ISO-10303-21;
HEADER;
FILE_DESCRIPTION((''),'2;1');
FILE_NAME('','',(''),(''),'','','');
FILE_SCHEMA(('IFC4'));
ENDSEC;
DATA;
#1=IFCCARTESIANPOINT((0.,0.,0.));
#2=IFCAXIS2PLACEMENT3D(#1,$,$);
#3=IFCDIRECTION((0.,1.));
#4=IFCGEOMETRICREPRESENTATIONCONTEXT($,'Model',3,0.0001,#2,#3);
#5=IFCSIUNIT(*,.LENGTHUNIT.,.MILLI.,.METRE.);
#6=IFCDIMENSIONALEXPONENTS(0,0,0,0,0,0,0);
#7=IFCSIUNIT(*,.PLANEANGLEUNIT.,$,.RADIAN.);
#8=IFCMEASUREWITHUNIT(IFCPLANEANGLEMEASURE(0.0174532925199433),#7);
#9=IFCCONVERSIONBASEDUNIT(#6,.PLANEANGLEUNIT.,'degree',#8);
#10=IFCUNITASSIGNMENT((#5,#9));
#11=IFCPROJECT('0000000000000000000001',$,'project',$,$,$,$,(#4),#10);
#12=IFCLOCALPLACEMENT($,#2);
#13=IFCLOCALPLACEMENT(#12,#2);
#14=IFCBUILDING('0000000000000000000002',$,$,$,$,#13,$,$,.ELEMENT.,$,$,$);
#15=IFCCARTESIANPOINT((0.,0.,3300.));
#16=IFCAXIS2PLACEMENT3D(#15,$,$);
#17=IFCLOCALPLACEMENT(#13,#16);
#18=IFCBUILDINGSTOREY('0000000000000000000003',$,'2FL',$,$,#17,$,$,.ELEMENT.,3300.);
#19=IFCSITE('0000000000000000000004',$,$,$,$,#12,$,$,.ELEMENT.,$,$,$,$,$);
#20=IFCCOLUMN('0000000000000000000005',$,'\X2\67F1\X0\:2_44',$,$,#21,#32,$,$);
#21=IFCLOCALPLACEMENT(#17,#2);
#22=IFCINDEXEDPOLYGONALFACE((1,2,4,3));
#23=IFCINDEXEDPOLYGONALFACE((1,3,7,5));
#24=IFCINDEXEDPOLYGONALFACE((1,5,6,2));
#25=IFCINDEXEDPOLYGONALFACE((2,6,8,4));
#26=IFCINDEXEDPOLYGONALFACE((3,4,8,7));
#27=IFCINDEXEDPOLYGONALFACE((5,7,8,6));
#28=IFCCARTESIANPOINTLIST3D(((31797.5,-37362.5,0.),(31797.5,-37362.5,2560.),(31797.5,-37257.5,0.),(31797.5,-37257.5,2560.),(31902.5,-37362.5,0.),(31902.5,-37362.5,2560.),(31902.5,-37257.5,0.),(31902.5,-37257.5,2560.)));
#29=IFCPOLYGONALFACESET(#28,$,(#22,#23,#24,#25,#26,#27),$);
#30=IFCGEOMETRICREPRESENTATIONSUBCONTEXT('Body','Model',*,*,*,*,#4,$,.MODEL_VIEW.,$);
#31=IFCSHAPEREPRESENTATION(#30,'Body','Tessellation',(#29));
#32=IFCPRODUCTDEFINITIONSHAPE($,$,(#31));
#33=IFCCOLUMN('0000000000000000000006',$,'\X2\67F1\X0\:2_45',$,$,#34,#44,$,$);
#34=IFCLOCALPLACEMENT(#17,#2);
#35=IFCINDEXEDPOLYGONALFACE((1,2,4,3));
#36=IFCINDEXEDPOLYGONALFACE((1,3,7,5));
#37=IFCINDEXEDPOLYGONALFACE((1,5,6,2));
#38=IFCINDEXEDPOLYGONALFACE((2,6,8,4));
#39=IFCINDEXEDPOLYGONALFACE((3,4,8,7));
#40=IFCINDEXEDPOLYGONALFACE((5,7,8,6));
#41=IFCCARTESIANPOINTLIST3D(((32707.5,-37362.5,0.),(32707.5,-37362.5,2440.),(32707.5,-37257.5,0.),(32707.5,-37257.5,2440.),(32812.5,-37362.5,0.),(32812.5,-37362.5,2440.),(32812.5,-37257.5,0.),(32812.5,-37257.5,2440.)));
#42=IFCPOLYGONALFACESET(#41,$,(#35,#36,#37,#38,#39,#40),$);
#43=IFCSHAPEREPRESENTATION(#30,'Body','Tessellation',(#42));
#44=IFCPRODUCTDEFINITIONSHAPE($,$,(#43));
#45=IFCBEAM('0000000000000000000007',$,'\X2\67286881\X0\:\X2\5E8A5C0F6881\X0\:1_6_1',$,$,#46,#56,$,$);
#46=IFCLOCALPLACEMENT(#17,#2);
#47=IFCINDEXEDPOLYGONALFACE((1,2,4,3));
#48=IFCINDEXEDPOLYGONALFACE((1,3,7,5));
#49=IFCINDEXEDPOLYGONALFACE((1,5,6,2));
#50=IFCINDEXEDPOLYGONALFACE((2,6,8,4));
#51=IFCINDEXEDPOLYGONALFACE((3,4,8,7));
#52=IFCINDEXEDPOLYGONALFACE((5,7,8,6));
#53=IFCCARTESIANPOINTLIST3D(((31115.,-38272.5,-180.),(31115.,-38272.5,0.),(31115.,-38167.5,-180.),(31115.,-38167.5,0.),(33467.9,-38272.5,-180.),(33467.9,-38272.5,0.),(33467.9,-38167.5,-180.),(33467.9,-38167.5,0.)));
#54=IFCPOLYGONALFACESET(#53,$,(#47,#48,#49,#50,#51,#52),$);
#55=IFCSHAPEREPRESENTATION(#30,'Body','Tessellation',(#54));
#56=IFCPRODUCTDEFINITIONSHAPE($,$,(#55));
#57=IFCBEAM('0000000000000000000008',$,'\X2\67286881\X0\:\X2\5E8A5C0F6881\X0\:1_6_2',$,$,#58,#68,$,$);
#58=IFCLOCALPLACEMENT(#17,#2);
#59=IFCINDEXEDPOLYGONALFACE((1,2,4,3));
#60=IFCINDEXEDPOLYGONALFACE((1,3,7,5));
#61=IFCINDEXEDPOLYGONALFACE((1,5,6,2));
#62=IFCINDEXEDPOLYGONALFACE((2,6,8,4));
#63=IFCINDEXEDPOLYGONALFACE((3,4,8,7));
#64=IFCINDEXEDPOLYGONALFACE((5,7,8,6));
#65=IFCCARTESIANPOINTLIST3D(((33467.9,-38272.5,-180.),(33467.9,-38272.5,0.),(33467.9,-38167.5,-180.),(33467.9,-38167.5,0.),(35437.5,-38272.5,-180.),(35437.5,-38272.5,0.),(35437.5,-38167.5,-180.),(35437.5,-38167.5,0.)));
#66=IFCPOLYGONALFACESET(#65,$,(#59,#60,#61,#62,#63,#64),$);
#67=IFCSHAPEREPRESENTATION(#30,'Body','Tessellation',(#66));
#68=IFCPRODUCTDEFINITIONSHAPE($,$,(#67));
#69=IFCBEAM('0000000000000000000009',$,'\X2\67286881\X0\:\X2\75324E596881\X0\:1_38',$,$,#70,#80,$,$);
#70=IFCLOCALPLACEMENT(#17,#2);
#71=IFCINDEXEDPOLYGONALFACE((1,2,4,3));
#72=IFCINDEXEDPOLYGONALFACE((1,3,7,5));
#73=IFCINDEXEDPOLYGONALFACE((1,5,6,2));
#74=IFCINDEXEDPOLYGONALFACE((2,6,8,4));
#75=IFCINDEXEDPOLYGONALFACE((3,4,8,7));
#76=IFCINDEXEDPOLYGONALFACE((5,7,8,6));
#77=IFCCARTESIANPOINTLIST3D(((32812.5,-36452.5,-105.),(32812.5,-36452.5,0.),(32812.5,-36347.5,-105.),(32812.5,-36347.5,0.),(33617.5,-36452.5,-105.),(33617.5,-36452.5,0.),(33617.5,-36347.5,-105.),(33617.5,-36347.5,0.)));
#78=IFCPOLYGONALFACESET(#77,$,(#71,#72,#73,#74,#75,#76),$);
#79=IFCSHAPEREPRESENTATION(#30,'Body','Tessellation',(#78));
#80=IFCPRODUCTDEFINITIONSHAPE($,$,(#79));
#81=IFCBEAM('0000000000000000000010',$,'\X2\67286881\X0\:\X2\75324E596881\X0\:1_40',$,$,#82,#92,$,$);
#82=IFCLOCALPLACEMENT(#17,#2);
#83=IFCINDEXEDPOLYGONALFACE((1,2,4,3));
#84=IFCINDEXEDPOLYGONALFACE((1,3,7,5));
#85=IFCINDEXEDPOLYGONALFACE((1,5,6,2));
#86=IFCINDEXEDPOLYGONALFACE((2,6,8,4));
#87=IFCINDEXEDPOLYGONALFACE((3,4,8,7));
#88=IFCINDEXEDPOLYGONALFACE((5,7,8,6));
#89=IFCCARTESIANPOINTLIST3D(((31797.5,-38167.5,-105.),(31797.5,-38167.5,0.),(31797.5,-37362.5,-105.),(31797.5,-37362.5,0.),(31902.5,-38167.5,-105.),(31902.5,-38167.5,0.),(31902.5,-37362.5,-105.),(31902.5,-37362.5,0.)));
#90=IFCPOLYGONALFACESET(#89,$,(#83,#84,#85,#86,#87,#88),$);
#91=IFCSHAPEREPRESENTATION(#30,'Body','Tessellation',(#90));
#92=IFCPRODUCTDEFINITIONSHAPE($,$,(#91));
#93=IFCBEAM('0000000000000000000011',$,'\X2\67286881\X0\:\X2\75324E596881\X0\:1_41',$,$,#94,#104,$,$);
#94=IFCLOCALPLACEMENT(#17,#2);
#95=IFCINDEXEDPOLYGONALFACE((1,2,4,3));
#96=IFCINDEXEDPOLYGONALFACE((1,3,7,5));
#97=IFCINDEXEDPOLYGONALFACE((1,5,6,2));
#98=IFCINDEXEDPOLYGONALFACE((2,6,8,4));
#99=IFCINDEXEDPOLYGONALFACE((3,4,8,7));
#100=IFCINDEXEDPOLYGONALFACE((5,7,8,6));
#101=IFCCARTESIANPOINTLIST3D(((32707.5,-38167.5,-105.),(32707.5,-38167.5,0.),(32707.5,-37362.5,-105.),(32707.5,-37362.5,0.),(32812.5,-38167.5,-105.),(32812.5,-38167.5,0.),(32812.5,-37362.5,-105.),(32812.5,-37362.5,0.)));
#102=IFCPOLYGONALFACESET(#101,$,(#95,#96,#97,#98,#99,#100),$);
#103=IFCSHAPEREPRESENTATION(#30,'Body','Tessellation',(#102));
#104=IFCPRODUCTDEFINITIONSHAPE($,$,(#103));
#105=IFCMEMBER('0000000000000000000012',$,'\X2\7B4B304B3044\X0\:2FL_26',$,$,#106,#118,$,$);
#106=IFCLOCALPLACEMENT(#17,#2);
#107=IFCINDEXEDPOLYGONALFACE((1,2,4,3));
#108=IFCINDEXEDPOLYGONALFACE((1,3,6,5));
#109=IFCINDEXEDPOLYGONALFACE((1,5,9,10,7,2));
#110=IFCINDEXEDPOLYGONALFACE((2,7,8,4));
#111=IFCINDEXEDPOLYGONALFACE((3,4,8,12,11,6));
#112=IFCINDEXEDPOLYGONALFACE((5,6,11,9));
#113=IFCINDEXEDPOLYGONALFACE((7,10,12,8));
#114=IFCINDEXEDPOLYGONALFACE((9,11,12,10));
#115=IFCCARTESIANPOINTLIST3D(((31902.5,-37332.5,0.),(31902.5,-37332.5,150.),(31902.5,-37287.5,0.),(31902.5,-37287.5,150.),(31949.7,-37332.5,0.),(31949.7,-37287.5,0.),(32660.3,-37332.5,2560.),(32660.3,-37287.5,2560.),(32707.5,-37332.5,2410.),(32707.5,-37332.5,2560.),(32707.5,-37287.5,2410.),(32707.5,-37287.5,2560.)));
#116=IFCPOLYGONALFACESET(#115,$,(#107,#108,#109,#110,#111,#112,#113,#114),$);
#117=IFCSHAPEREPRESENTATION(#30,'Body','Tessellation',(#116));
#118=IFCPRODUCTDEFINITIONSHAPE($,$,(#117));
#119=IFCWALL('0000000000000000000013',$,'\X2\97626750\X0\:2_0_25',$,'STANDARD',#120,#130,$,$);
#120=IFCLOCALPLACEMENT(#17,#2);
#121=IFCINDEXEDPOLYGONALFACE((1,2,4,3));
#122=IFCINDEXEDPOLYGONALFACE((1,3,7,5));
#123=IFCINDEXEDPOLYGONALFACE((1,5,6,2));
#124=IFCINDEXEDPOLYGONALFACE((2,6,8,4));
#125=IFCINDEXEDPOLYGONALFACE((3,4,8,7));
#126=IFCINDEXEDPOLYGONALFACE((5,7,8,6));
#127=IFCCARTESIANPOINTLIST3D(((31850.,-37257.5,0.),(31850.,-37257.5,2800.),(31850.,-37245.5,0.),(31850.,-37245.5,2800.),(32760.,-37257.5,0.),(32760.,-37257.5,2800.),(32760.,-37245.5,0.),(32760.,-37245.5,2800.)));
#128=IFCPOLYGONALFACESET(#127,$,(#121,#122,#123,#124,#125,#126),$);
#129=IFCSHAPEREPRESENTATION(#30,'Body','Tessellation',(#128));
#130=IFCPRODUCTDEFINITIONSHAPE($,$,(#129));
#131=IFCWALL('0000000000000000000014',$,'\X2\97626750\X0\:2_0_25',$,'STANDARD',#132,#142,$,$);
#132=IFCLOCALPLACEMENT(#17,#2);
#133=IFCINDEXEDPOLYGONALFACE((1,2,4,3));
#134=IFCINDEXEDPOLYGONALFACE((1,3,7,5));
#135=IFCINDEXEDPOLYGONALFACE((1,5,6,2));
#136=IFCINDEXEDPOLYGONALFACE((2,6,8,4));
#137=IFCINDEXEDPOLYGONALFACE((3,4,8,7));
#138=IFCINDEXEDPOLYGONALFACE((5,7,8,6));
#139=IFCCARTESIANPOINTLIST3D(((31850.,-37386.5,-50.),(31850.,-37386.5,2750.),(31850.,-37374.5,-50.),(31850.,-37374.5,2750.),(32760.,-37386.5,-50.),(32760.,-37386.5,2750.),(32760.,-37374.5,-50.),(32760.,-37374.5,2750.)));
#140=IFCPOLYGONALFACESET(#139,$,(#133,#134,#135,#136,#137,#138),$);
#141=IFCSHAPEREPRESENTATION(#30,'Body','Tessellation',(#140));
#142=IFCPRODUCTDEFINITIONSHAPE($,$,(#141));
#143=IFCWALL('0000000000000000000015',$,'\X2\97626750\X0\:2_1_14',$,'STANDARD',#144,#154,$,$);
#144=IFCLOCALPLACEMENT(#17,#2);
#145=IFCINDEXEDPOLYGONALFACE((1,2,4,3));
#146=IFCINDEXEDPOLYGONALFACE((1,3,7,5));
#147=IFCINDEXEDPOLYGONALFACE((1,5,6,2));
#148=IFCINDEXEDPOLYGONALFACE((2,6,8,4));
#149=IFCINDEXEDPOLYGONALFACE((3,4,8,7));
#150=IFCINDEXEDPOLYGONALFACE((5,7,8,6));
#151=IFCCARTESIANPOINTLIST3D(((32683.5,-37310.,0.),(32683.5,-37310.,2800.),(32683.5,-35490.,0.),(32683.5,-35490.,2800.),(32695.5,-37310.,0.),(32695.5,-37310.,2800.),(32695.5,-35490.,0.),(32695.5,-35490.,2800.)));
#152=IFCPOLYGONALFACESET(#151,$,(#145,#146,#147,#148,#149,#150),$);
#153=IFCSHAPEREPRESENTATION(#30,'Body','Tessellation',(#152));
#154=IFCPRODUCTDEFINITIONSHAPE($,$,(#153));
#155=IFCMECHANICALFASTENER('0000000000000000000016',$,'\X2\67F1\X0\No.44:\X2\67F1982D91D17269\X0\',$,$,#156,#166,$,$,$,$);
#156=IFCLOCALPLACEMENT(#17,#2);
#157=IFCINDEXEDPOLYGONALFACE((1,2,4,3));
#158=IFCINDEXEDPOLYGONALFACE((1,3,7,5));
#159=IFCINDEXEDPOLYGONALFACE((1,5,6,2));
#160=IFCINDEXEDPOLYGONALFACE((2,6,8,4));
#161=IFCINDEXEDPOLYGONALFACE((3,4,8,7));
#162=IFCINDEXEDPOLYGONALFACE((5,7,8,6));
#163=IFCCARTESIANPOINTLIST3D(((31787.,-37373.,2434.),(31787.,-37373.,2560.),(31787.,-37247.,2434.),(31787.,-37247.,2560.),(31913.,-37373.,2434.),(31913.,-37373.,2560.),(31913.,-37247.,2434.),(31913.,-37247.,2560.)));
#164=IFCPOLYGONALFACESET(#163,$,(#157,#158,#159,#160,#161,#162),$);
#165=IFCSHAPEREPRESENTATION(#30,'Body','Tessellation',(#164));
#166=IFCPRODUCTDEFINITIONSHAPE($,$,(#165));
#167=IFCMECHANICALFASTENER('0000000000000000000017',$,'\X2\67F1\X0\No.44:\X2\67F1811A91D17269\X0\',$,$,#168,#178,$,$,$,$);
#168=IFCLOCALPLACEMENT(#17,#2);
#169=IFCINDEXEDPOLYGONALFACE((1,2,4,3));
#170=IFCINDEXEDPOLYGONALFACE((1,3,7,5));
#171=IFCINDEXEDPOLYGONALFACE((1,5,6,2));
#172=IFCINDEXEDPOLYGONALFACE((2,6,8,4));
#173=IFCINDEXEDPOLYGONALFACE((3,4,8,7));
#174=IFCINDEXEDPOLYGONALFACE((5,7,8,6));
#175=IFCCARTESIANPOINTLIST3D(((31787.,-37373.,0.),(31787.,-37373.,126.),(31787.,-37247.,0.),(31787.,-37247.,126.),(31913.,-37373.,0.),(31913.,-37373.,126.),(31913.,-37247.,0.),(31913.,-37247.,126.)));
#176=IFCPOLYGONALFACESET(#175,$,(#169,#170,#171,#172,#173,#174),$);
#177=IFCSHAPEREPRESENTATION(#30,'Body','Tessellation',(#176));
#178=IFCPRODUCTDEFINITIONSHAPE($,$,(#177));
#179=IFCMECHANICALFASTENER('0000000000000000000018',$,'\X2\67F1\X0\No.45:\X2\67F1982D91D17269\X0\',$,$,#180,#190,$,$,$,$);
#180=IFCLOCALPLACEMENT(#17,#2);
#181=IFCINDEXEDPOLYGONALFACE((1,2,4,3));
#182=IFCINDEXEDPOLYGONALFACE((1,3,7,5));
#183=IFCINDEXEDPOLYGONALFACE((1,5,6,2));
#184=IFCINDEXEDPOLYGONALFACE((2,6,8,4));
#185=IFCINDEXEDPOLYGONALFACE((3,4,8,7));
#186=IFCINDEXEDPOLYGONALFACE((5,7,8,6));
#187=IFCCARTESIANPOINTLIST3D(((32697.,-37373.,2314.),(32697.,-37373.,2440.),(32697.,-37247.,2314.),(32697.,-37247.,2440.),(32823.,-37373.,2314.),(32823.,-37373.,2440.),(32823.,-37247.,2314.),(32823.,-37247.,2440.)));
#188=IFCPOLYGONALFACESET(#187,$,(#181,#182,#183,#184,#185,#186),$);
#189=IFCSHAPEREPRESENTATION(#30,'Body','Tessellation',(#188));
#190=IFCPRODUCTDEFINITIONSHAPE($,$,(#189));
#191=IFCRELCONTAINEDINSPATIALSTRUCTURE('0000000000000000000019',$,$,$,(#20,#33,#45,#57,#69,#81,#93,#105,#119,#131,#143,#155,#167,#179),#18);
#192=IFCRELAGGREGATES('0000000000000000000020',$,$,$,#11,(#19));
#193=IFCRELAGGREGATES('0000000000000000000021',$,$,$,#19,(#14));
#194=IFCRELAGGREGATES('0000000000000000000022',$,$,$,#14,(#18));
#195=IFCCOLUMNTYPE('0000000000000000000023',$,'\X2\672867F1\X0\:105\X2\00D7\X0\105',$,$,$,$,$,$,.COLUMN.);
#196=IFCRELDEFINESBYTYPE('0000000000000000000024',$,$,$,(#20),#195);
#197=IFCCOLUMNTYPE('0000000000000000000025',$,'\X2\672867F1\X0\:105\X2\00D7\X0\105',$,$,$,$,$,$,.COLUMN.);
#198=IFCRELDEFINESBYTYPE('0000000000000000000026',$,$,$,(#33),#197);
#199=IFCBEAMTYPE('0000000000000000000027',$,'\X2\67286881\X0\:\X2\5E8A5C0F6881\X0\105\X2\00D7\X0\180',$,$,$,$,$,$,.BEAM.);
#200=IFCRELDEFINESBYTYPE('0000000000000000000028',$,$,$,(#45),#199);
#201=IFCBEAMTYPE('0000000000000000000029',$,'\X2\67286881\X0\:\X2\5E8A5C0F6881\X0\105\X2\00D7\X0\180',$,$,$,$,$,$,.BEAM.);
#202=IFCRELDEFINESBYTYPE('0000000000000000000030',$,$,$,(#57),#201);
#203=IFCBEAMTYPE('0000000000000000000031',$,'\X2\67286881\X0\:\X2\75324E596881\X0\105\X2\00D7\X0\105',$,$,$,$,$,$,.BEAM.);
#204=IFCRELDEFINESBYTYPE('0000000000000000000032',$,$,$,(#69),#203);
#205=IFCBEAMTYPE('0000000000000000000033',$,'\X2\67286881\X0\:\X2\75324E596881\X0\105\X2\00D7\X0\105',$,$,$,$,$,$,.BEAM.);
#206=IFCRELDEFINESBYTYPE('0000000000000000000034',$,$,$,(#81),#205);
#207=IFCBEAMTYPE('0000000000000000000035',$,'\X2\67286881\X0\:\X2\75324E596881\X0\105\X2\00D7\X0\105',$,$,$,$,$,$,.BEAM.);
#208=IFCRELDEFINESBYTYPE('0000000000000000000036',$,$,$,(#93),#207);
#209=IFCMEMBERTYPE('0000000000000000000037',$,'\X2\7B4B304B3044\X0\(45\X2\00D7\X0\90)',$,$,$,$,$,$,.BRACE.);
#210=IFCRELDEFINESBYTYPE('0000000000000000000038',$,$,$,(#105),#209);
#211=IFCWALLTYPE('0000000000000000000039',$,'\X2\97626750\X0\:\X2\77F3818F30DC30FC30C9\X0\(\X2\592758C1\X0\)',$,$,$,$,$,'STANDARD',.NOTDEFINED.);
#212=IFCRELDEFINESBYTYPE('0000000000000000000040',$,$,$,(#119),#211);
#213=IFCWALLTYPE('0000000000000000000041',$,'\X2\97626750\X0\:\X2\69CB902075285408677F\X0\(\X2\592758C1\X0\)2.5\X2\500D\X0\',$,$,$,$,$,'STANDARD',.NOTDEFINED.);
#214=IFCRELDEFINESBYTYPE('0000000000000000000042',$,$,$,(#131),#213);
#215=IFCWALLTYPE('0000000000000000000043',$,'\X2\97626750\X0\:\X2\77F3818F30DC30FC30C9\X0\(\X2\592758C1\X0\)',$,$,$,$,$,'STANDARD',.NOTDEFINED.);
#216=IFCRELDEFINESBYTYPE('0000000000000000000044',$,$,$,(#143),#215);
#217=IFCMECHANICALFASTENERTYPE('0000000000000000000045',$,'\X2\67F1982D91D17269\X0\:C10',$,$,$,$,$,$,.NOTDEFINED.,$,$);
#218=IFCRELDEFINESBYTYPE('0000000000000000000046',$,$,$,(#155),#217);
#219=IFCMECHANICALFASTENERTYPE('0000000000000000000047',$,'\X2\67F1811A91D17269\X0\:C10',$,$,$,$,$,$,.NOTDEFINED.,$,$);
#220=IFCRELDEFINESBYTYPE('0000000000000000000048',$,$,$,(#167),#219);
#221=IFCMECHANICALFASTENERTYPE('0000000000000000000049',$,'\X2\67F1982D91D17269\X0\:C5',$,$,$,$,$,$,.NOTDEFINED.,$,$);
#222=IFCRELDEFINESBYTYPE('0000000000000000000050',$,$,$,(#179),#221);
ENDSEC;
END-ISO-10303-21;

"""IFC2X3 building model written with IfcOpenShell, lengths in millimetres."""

from ifc_helpers import new_model, entity, si_unit, converted_unit, direction, frame, origin, origin_with_axes, origin_2d, place, context, subcontext, project, spatial, polyline, rectangle, outline, extrude, type_object, element, save


model = new_model("IFC2X3")

# Units and contexts
model_context = context("Model", 3, precision=0.0001, world=origin(), true_north=direction((0.0, 1.0)))
body_context = subcontext(model_context, "Body", "Model", "MODEL_VIEW")
ifc_project = project(units=[si_unit("LENGTHUNIT", "METRE", prefix="MILLI"), converted_unit("PLANEANGLEUNIT", "degree", entity("IfcPlaneAngleMeasure", 0.0174532925199433), si_unit("PLANEANGLEUNIT", "RADIAN"), dimensions=[0, 0, 0, 0, 0, 0, 0])], contexts=[model_context])

# Site, building, storey
site_placement = place(None, origin())
site = spatial("IfcSite", under=ifc_project, at=site_placement, CompositionType="ELEMENT")
building_placement = place(site_placement, origin())
building = spatial("IfcBuilding", under=site, at=building_placement, CompositionType="ELEMENT")
storey_placement = place(building_placement, frame((0.0, 0.0, 3300.0)))
storey = spatial("IfcBuildingStorey", under=building, at=storey_placement, Name="2FL", CompositionType="ELEMENT", Elevation=3300.0)

# Columns
column_type_1 = type_object("IfcColumnType", Name="木柱:105×105", PredefinedType="COLUMN")
column_1_placement = place(storey_placement, frame((31850.0, -37310.0, 0.0)))
element("IfcColumn", 1, at=column_1_placement, inside=storey, type_object=column_type_1, Name="柱:2_44", context=body_context, shape_type="SweptSolid", body=[
    extrude(rectangle(XDim=105.0, YDim=105.0, at=origin_2d()), origin_with_axes(), (0.0, 0.0, 1.0), 2560.0),
])
column_type_2 = type_object("IfcColumnType", Name="木柱:105×105", PredefinedType="COLUMN")
column_2_placement = place(storey_placement, frame((32760.0, -37310.0, 0.0)))
element("IfcColumn", 2, at=column_2_placement, inside=storey, type_object=column_type_2, Name="柱:2_45", context=body_context, shape_type="SweptSolid", body=[
    extrude(rectangle(XDim=105.0, YDim=105.0, at=origin_2d()), origin_with_axes(), (0.0, 0.0, 1.0), 2440.0),
])

# Beams
beam_type_1 = type_object("IfcBeamType", Name="木梁:床小梁105×180", PredefinedType="BEAM")
beam_1_placement = place(storey_placement, frame((31115.0, -38220.0, -90.0), z_axis=(1.0, 0.0, 0.0), x_axis=(0.0, 1.0, 0.0)))
element("IfcBeam", 3, at=beam_1_placement, inside=storey, type_object=beam_type_1, Name="木梁:床小梁:1_6_1", context=body_context, shape_type="SweptSolid", body=[
    extrude(rectangle(XDim=105.0, YDim=180.0, at=origin_2d()), origin_with_axes(), (0.0, 0.0, 1.0), 2352.8),
])
beam_type_2 = type_object("IfcBeamType", Name="木梁:床小梁105×180", PredefinedType="BEAM")
beam_2_placement = place(storey_placement, frame((33467.9, -38220.0, -90.0), z_axis=(1.0, 0.0, 0.0), x_axis=(0.0, 1.0, 0.0)))
element("IfcBeam", 4, at=beam_2_placement, inside=storey, type_object=beam_type_2, Name="木梁:床小梁:1_6_2", context=body_context, shape_type="SweptSolid", body=[
    extrude(rectangle(XDim=105.0, YDim=180.0, at=origin_2d()), origin_with_axes(), (0.0, 0.0, 1.0), 1969.6),
])
beam_type_3 = type_object("IfcBeamType", Name="木梁:甲乙梁105×105", PredefinedType="BEAM")
beam_3_placement = place(storey_placement, frame((32812.5, -36400.0, -52.5), z_axis=(1.0, 0.0, 0.0), x_axis=(0.0, 1.0, 0.0)))
element("IfcBeam", 5, at=beam_3_placement, inside=storey, type_object=beam_type_3, Name="木梁:甲乙梁:1_38", context=body_context, shape_type="SweptSolid", body=[
    extrude(rectangle(XDim=105.0, YDim=105.0, at=origin_2d()), origin_with_axes(), (0.0, 0.0, 1.0), 805.0),
])
beam_type_4 = type_object("IfcBeamType", Name="木梁:甲乙梁105×105", PredefinedType="BEAM")
beam_4_placement = place(storey_placement, frame((31850.0, -37362.5, -52.5), z_axis=(0.0, -1.0, 0.0), x_axis=(1.0, 0.0, 0.0)))
element("IfcBeam", 6, at=beam_4_placement, inside=storey, type_object=beam_type_4, Name="木梁:甲乙梁:1_40", context=body_context, shape_type="SweptSolid", body=[
    extrude(rectangle(XDim=105.0, YDim=105.0, at=origin_2d()), origin_with_axes(), (0.0, 0.0, 1.0), 805.0),
])
beam_type_5 = type_object("IfcBeamType", Name="木梁:甲乙梁105×105", PredefinedType="BEAM")
beam_5_placement = place(storey_placement, frame((32760.0, -37362.5, -52.5), z_axis=(0.0, -1.0, 0.0), x_axis=(1.0, 0.0, 0.0)))
element("IfcBeam", 7, at=beam_5_placement, inside=storey, type_object=beam_type_5, Name="木梁:甲乙梁:1_41", context=body_context, shape_type="SweptSolid", body=[
    extrude(rectangle(XDim=105.0, YDim=105.0, at=origin_2d()), origin_with_axes(), (0.0, 0.0, 1.0), 805.0),
])

# Member
member_type = type_object("IfcMemberType", Name="筋かい(45×90)", PredefinedType="BRACE")
member_placement = place(storey_placement, frame((31902.5, -37310.0, 0.0), z_axis=(0.299972, 0.0, 0.953948), x_axis=(-0.953948, 0.0, 0.299972)))
element("IfcMember", 8, at=member_placement, inside=storey, type_object=member_type, Name="筋かい:2FL_26", context=body_context, shape_type="SweptSolid", body=[
    extrude(outline(polyline([(0.0, 0.0), (14.2, -45.0), (2540.5, -45.0), (2683.6, 0.0), (2669.4, 45.0), (143.1, 45.0), (0.0, 0.0)])), frame((0.0, -22.5, 0.0), z_axis=(0.0, 1.0, 0.0), x_axis=(0.0, 0.0, 1.0)), (0.0, 0.0, 1.0), 45.0),
])

# Walls
wall_type_1 = type_object("IfcWallType", Name="面材:石膏ボード(大壁)", ElementType="STANDARD", PredefinedType="NOTDEFINED")
wall_1_placement = place(storey_placement, frame((32305.0, -37245.5, 0.0), z_axis=(0.0, -1.0, 0.0), x_axis=(1.0, 0.0, 0.0)))
element("IfcWall", 9, at=wall_1_placement, inside=storey, type_object=wall_type_1, Name="面材:2_0_25", ObjectType="STANDARD", context=body_context, shape_type="SweptSolid", body=[
    extrude(outline(polyline([(455.0, 0.0, 0.0), (-455.0, 0.0, 0.0), (-455.0, 2800.0, 0.0), (455.0, 2800.0, 0.0), (455.0, 0.0, 0.0)])), origin_with_axes(), (0.0, 0.0, 1.0), 12.0),
])
wall_type_2 = type_object("IfcWallType", Name="面材:構造用合板(大壁)2.5倍", ElementType="STANDARD", PredefinedType="NOTDEFINED")
wall_2_placement = place(storey_placement, frame((32305.0, -37374.5, -50.0), z_axis=(0.0, -1.0, 0.0), x_axis=(1.0, 0.0, 0.0)))
element("IfcWall", 10, at=wall_2_placement, inside=storey, type_object=wall_type_2, Name="面材:2_0_25", ObjectType="STANDARD", context=body_context, shape_type="SweptSolid", body=[
    extrude(outline(polyline([(455.0, 0.0, 0.0), (-455.0, 0.0, 0.0), (-455.0, 2800.0, 0.0), (455.0, 2800.0, 0.0), (455.0, 0.0, 0.0)])), origin_with_axes(), (0.0, 0.0, 1.0), 12.0),
])
wall_type_3 = type_object("IfcWallType", Name="面材:石膏ボード(大壁)", ElementType="STANDARD", PredefinedType="NOTDEFINED")
wall_3_placement = place(storey_placement, frame((32695.5, -36400.0, 0.0), z_axis=(-1.0, 0.0, 0.0), x_axis=(0.0, -1.0, 0.0)))
element("IfcWall", 11, at=wall_3_placement, inside=storey, type_object=wall_type_3, Name="面材:2_1_14", ObjectType="STANDARD", context=body_context, shape_type="SweptSolid", body=[
    extrude(outline(polyline([(910.0, 0.0, 0.0), (-910.0, 0.0, 0.0), (-910.0, 2800.0, 0.0), (910.0, 2800.0, 0.0), (910.0, 0.0, 0.0)])), origin_with_axes(), (0.0, 0.0, 1.0), 12.0),
])

# Mechanical fasteners
mechanical_fastener_type_1 = type_object("IfcMechanicalFastenerType", Name="柱頭金物:C10")
mechanical_fastener_1_placement = place(storey_placement, frame((31850.0, -37310.0, 2434.0)))
element("IfcMechanicalFastener", 12, at=mechanical_fastener_1_placement, inside=storey, type_object=mechanical_fastener_type_1, Name="柱No.44:柱頭金物", context=body_context, shape_type="SweptSolid", body=[
    extrude(rectangle(XDim=126.0, YDim=126.0, at=origin_2d()), origin_with_axes(), (0.0, 0.0, 1.0), 126.0),
])
mechanical_fastener_type_2 = type_object("IfcMechanicalFastenerType", Name="柱脚金物:C10")
mechanical_fastener_2_placement = place(storey_placement, frame((31850.0, -37310.0, 0.0)))
element("IfcMechanicalFastener", 13, at=mechanical_fastener_2_placement, inside=storey, type_object=mechanical_fastener_type_2, Name="柱No.44:柱脚金物", context=body_context, shape_type="SweptSolid", body=[
    extrude(rectangle(XDim=126.0, YDim=126.0, at=origin_2d()), origin_with_axes(), (0.0, 0.0, 1.0), 126.0),
])
mechanical_fastener_type_3 = type_object("IfcMechanicalFastenerType", Name="柱頭金物:C5")
mechanical_fastener_3_placement = place(storey_placement, frame((32760.0, -37310.0, 2314.0)))
element("IfcMechanicalFastener", 14, at=mechanical_fastener_3_placement, inside=storey, type_object=mechanical_fastener_type_3, Name="柱No.45:柱頭金物", context=body_context, shape_type="SweptSolid", body=[
    extrude(rectangle(XDim=126.0, YDim=126.0, at=origin_2d()), origin_with_axes(), (0.0, 0.0, 1.0), 126.0),
])

save(model, "model.ifc")
